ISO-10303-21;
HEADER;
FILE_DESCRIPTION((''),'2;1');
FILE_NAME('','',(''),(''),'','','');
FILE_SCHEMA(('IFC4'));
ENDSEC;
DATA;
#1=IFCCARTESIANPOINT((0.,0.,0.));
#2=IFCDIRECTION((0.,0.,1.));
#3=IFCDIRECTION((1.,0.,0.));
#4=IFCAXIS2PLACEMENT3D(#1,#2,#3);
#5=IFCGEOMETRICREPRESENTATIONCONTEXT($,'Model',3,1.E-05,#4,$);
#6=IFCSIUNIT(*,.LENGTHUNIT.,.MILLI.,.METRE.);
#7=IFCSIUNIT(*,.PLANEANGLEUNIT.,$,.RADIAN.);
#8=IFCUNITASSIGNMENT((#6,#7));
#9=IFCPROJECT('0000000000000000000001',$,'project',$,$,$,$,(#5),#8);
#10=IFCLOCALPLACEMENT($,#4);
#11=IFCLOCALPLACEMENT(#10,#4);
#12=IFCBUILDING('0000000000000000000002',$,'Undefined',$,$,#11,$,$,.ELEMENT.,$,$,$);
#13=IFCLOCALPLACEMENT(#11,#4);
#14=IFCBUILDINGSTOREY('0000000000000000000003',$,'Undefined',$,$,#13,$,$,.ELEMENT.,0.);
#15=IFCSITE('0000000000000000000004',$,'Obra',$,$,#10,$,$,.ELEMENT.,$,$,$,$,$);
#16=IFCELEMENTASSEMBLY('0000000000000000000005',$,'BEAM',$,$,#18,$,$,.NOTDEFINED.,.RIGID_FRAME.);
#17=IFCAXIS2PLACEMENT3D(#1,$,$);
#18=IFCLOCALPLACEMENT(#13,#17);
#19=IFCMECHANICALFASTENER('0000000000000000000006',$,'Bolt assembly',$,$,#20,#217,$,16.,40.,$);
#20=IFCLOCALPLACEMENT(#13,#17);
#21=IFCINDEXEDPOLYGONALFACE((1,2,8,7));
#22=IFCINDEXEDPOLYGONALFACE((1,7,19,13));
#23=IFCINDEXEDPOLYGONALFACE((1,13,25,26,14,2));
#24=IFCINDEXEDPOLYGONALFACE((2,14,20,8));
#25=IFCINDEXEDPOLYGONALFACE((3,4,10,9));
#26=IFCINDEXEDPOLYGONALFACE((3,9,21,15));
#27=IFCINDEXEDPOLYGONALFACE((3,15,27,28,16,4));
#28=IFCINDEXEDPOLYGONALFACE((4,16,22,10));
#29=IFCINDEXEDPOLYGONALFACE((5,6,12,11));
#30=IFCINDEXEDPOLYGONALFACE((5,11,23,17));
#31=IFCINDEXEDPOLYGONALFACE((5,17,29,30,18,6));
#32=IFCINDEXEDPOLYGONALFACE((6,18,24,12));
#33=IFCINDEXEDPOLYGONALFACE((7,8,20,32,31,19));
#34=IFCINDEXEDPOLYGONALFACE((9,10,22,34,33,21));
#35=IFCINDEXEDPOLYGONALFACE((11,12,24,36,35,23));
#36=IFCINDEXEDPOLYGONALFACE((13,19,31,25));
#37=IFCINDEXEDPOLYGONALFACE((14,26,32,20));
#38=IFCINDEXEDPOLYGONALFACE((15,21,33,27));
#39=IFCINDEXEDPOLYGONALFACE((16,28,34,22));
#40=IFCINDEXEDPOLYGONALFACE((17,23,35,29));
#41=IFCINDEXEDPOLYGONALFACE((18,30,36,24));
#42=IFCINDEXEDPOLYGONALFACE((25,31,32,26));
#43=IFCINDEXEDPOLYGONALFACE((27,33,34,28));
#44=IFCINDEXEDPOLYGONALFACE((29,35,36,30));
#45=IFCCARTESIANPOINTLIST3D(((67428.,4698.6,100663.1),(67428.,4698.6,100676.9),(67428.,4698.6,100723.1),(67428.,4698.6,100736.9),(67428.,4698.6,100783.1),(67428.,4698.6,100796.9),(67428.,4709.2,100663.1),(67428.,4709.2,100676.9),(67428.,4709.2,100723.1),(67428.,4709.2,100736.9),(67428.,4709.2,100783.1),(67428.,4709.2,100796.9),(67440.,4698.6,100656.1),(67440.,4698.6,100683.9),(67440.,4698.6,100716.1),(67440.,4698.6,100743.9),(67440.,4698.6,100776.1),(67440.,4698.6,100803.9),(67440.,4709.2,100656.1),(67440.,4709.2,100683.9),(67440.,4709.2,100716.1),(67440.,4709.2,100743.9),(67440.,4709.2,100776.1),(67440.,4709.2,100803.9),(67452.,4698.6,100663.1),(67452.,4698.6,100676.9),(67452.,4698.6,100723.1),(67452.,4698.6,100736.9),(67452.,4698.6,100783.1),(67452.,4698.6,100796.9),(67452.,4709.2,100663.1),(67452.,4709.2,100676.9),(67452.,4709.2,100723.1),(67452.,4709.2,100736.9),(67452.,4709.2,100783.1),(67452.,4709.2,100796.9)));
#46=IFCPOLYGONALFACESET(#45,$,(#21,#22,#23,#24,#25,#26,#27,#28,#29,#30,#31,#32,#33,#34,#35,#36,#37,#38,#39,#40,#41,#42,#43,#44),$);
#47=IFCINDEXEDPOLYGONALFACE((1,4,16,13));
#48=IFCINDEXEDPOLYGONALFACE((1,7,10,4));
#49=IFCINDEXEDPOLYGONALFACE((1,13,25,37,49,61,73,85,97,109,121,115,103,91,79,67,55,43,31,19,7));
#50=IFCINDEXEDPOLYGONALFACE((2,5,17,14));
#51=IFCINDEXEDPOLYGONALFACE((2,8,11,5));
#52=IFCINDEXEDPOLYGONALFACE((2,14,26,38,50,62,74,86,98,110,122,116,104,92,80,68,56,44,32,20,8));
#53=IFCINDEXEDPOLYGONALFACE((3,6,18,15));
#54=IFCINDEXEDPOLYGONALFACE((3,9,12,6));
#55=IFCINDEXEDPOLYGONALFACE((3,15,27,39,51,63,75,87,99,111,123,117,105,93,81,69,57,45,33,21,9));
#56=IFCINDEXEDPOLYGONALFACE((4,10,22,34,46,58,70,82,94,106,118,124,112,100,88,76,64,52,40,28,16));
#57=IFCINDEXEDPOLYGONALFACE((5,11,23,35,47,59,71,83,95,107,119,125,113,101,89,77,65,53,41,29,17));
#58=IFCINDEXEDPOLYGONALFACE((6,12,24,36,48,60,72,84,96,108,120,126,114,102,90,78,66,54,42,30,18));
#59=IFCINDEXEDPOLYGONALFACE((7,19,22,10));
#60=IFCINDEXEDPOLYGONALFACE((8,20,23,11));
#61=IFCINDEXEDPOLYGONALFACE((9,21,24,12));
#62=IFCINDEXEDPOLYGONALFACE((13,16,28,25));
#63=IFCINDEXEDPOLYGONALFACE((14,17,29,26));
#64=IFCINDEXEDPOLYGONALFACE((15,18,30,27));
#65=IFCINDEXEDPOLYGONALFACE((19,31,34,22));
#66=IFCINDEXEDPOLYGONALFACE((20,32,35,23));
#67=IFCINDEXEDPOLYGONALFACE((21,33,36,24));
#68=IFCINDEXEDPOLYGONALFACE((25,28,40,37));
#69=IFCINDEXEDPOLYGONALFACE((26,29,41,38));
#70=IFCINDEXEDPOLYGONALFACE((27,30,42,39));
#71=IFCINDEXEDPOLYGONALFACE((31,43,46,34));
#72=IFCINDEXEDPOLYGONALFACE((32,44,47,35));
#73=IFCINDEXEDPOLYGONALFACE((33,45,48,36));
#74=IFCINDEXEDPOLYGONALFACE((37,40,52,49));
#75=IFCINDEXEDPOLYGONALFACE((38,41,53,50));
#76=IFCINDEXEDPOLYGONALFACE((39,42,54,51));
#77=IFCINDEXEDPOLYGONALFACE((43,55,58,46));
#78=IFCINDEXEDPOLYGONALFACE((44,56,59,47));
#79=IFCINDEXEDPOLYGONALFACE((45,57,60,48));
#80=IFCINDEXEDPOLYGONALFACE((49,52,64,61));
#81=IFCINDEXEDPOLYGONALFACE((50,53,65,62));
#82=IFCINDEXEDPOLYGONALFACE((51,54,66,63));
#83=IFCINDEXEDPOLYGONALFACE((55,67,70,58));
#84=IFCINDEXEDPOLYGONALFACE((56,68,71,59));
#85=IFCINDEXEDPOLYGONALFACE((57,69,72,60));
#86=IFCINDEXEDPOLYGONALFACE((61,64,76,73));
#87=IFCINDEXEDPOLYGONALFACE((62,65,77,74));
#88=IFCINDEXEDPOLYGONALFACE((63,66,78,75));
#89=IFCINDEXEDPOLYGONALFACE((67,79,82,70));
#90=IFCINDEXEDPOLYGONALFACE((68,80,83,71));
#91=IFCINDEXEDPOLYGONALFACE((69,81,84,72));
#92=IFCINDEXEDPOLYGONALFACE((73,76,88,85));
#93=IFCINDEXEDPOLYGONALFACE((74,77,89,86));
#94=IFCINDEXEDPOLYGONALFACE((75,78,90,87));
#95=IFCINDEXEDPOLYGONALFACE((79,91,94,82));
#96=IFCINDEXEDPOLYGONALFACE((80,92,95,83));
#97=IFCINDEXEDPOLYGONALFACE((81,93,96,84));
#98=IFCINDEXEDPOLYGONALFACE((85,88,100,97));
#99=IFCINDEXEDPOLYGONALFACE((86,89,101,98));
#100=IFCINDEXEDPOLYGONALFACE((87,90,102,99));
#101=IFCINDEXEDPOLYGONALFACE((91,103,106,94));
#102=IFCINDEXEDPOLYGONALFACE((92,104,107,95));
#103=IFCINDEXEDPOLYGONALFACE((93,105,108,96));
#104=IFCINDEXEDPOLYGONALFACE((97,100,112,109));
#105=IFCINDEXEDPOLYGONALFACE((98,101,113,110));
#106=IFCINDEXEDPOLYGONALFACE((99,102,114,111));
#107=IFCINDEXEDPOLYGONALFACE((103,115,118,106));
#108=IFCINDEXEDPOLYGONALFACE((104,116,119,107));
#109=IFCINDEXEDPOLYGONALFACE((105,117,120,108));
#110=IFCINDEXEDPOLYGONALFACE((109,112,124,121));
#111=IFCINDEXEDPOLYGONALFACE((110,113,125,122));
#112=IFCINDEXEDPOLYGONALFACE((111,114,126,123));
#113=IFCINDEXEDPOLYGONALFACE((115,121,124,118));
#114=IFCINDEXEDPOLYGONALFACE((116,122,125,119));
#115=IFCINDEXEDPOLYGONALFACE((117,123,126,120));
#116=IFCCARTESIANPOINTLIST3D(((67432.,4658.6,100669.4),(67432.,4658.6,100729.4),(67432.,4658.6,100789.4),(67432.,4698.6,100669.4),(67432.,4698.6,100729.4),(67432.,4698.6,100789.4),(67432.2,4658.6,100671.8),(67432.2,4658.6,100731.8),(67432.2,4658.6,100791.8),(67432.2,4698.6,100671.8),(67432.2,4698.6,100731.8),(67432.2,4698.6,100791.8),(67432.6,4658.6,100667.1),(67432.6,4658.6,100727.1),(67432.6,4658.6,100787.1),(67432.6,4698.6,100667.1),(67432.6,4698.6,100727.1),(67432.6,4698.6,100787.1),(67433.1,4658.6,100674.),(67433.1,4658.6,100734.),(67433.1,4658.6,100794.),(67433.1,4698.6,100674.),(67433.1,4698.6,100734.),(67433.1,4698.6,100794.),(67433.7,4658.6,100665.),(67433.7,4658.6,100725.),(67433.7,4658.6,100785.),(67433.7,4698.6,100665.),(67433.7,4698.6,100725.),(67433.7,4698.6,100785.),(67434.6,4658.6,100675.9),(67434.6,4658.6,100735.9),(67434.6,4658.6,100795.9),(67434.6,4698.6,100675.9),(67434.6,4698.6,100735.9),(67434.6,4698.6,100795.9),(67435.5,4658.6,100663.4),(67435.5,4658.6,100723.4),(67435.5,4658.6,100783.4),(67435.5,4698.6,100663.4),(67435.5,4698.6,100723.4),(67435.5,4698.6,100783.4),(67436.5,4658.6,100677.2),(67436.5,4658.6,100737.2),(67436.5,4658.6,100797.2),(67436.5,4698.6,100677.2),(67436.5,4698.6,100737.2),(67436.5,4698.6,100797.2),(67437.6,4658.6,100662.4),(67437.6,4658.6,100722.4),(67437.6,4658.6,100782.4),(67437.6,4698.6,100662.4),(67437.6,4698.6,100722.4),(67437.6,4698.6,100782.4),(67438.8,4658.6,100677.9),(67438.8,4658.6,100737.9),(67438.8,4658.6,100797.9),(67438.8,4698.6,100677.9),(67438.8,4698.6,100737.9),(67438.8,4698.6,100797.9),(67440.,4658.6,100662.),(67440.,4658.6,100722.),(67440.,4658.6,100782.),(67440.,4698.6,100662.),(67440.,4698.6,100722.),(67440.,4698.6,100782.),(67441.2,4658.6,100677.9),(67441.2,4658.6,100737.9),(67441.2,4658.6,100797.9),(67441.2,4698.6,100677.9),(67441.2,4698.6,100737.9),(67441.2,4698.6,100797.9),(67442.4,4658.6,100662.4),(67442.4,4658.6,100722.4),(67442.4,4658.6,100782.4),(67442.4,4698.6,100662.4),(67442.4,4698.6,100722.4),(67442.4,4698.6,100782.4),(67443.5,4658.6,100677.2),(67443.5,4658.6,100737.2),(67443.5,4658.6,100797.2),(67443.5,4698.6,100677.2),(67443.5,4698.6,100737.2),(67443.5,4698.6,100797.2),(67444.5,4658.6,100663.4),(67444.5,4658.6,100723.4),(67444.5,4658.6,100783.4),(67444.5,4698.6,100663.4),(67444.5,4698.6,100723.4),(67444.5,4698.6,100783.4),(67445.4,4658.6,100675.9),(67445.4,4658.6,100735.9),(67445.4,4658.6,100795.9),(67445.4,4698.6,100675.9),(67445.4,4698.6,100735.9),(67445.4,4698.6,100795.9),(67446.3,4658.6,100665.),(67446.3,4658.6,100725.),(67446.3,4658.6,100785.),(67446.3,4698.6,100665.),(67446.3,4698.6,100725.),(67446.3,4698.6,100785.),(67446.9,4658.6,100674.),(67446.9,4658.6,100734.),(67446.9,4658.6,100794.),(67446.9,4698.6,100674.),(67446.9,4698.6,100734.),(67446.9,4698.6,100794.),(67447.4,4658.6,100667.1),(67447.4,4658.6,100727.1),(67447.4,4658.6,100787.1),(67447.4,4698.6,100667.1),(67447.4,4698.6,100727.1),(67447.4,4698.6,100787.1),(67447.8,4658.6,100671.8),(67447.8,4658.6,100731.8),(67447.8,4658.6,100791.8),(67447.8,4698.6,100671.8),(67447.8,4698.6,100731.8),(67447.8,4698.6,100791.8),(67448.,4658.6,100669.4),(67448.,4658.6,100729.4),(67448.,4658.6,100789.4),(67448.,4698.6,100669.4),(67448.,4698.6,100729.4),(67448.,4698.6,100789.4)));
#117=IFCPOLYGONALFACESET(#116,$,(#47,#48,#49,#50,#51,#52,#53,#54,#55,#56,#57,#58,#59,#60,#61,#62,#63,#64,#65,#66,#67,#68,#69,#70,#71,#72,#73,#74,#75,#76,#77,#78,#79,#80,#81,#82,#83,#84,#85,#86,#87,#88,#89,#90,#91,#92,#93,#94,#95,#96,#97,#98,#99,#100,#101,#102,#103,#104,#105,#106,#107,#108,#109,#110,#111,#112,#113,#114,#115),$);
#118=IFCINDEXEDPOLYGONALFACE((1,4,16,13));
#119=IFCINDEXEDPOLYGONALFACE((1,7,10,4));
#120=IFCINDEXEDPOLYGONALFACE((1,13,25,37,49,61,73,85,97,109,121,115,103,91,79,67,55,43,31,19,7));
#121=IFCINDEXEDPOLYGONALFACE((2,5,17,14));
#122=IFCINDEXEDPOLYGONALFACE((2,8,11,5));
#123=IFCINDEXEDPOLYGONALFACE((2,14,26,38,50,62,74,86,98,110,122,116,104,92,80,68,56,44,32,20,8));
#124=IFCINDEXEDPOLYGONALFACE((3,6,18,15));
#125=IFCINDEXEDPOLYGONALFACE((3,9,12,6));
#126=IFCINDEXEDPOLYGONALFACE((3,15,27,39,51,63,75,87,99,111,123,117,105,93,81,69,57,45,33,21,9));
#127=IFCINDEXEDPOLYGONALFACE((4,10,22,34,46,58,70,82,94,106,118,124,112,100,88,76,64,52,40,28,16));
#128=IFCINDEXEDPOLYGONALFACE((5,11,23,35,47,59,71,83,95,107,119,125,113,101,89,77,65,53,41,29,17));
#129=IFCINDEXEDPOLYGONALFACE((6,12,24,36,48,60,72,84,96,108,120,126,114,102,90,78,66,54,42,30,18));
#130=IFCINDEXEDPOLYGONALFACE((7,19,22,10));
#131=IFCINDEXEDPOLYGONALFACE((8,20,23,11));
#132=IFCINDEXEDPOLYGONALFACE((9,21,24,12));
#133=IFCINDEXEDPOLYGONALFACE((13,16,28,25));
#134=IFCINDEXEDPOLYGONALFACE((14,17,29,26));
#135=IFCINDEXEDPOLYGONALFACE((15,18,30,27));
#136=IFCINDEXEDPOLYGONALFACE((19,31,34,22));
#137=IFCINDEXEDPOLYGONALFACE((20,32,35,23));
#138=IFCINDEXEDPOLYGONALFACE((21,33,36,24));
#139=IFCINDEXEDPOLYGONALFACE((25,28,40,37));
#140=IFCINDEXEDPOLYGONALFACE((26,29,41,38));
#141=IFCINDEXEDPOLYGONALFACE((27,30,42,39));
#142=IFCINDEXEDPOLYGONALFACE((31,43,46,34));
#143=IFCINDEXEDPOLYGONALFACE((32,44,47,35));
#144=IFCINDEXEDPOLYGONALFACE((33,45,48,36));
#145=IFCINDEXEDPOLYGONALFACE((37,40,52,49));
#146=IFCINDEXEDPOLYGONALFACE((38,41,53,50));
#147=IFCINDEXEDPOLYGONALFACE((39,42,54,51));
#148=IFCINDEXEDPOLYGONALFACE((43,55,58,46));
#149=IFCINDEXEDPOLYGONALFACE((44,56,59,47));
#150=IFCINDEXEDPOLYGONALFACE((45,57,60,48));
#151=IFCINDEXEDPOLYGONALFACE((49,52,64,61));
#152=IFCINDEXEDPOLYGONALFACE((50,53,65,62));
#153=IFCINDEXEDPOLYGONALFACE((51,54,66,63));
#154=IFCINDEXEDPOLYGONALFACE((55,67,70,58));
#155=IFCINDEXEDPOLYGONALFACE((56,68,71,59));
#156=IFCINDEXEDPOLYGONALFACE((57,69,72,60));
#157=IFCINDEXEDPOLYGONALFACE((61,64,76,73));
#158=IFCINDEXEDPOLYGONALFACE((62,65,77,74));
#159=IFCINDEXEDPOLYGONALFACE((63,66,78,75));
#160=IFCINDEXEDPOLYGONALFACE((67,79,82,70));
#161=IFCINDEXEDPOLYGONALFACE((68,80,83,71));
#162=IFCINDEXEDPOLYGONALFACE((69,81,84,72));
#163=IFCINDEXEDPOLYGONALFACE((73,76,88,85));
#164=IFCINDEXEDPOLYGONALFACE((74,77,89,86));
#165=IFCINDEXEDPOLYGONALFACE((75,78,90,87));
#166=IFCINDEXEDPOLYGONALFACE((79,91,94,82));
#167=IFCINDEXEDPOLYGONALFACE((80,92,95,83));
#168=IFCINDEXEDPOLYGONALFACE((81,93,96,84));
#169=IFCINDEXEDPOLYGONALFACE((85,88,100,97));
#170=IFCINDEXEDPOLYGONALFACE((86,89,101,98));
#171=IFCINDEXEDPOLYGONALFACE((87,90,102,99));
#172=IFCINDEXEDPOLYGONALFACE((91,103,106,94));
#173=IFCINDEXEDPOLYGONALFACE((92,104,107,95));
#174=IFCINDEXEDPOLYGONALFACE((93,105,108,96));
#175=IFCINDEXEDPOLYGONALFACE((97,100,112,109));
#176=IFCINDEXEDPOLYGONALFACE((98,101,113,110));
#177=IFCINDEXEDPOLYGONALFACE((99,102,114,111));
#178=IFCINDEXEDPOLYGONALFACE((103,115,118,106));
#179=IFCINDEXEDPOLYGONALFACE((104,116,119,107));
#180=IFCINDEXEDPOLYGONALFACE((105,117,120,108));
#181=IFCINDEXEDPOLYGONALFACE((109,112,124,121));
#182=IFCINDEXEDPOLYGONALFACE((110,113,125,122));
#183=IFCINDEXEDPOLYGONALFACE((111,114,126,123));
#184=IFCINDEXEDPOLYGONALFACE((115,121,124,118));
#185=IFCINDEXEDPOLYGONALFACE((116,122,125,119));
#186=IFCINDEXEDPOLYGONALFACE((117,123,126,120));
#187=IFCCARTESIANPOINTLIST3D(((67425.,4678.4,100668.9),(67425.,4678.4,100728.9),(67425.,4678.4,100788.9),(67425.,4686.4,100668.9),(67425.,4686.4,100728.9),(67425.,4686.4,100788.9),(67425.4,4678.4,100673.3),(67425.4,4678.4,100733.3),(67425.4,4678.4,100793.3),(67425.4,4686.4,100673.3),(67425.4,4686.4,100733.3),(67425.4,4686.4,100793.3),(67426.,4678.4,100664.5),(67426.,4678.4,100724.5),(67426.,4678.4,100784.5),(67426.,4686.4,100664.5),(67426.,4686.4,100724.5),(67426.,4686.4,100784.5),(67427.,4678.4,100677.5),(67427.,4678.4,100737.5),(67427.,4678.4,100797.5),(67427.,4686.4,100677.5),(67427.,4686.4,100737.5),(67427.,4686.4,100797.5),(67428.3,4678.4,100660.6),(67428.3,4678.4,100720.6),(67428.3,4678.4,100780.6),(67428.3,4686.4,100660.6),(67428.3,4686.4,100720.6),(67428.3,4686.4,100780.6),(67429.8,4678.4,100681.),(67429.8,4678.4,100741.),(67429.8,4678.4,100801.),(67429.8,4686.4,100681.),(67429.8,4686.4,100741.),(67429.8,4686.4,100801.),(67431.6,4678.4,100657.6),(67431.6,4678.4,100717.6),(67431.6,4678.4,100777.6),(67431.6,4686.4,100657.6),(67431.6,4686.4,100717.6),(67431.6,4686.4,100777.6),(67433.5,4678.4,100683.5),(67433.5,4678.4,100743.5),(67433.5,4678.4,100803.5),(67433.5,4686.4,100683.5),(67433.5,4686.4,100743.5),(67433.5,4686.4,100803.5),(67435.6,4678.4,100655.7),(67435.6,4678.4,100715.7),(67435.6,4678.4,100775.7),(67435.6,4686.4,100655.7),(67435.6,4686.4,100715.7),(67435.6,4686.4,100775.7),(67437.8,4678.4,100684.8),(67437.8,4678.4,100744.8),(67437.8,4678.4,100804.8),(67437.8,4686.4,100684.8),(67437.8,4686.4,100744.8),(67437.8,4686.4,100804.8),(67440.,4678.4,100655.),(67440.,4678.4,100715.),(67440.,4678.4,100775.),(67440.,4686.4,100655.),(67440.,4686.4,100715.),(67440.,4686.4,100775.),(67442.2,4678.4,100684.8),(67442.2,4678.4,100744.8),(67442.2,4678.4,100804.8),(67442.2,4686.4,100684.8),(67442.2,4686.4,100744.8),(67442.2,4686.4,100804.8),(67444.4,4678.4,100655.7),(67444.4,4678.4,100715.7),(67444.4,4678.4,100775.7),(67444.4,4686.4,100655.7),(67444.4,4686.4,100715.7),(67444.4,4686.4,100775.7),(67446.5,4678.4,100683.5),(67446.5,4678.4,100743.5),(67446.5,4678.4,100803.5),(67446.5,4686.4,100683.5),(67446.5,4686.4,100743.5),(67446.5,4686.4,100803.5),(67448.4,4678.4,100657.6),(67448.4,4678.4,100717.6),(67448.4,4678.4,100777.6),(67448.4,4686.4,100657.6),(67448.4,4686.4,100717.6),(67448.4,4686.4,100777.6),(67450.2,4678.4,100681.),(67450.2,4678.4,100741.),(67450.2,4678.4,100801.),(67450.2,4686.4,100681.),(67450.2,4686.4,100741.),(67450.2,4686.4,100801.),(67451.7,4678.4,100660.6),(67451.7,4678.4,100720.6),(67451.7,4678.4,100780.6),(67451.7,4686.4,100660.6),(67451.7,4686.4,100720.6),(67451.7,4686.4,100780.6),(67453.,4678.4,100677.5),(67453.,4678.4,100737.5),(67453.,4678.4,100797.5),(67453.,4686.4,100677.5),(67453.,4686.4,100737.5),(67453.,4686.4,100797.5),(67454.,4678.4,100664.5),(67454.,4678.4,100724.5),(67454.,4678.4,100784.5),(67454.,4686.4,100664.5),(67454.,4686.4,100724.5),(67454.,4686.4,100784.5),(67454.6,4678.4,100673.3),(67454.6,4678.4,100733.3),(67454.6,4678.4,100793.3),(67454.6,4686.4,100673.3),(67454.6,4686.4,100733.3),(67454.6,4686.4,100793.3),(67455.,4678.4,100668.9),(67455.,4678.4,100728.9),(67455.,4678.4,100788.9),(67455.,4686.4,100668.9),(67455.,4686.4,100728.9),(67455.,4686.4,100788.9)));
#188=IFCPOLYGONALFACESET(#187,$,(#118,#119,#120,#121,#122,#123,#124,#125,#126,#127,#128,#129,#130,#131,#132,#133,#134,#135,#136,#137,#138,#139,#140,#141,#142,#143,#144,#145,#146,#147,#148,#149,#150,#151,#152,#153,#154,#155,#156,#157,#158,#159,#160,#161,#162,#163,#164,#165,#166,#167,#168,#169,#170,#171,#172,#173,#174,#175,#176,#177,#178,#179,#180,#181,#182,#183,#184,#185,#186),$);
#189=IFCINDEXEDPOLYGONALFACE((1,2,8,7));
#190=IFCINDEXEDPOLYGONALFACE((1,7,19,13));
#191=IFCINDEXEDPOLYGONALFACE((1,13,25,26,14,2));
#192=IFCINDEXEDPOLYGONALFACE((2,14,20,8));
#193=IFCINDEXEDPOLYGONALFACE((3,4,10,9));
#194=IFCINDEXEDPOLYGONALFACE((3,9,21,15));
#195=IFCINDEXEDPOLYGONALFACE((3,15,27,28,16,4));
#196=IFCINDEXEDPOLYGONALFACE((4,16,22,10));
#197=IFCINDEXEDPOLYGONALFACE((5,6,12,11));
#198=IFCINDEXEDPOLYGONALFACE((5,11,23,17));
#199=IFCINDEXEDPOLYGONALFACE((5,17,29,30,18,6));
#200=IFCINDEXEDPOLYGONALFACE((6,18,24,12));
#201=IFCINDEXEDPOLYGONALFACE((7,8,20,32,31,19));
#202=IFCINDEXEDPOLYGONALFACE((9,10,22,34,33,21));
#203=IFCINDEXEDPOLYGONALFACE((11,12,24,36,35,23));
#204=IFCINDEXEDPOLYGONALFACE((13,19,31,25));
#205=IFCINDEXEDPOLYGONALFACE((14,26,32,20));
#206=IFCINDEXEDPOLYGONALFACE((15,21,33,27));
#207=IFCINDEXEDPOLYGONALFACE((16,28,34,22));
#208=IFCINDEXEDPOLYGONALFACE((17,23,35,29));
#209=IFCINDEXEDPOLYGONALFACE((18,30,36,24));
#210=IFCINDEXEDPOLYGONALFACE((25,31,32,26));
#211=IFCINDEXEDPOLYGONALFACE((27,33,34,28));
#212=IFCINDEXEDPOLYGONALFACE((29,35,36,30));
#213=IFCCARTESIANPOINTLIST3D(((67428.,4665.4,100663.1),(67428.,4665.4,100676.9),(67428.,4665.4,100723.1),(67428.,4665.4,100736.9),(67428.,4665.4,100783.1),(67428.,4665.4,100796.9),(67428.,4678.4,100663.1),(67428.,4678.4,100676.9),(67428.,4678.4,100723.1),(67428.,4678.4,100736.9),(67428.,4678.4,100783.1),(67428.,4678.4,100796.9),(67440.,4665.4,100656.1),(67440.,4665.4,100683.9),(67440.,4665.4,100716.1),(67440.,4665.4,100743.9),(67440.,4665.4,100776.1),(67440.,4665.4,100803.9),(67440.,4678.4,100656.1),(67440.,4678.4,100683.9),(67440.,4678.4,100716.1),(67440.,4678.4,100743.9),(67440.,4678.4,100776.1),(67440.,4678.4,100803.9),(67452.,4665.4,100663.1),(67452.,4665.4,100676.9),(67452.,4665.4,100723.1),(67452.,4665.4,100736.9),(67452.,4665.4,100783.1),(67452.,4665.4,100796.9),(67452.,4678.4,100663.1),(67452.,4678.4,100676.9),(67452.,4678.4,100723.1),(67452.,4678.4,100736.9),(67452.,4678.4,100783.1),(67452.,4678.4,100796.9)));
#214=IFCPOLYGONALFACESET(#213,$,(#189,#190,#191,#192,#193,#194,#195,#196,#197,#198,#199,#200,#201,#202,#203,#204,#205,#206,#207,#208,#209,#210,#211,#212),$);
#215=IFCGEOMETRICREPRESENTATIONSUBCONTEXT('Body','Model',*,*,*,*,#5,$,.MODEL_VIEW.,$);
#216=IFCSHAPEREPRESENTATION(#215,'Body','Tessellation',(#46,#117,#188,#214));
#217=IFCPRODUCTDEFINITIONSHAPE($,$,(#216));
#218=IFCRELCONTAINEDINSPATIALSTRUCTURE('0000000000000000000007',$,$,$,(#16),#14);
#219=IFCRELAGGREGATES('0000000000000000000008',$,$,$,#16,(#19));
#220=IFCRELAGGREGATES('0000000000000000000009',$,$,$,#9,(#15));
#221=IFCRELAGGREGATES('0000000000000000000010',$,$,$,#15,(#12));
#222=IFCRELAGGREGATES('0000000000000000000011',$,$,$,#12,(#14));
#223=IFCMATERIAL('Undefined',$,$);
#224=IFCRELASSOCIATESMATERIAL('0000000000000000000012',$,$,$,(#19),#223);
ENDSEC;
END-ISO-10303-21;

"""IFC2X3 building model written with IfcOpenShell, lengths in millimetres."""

from ifc_helpers import new_model, si_unit, frame, origin_with_axes, origin_2d_with_axis, place, context, subcontext, project, spatial, polyline, circle, outline, extrude, source, transform, mapped, material, element, aggregate, save


model = new_model("IFC2X3")

# Units and contexts
model_context = context("Model", 3, precision=1e-05, world=origin_with_axes())
body_context = subcontext(model_context, "Body", "Model", "MODEL_VIEW")
ifc_project = project(units=[si_unit("LENGTHUNIT", "METRE", prefix="MILLI"), si_unit("PLANEANGLEUNIT", "RADIAN")], contexts=[model_context])

# Site, building, storey
site_placement = place(None, origin_with_axes())
site = spatial("IfcSite", under=ifc_project, at=site_placement, Name="Obra", CompositionType="ELEMENT")
building_placement = place(site_placement, origin_with_axes())
building = spatial("IfcBuilding", under=site, at=building_placement, Name="Undefined", CompositionType="ELEMENT")
storey_placement = place(building_placement, origin_with_axes())
storey = spatial("IfcBuildingStorey", under=building, at=storey_placement, Name="Undefined", CompositionType="ELEMENT", Elevation=0.0)

# Shared definitions
ifc_material_1 = material(Name="Undefined")

# Element assembly, mechanical fastener
assembly_1_placement = place(storey_placement, origin_with_axes())
assembly_1 = element("IfcElementAssembly", 1, at=assembly_1_placement, inside=storey, Name="BEAM", AssemblyPlace="NOTDEFINED", PredefinedType="RIGID_FRAME")
shared_shape_1 = source(origin_with_axes(), body_context, "Body", "SweptSolid", [
    extrude(outline(polyline([(13.9, 0.0), (6.9, 12.0), (-6.9, 12.0), (-13.9, 0.0), (-6.9, -12.0), (6.9, -12.0), (13.9, 0.0)])), frame((0.0, -19.7, 0.0), z_axis=(0.0, 1.0, 0.0), x_axis=(1.0, 0.0, 0.0)), (0.0, 0.0, 1.0), 10.6),
    extrude(circle(Radius=8.0, at=origin_2d_with_axis()), frame((0.0, -9.1, 0.0), z_axis=(0.0, 1.0, 0.0), x_axis=(1.0, 0.0, 0.0)), (0.0, 0.0, 1.0), 40.0),
    extrude(circle(Radius=15.0, at=origin_2d_with_axis()), frame((0.0, 3.1, 0.0), z_axis=(0.0, 1.0, 0.0), x_axis=(1.0, 0.0, 0.0)), (0.0, 0.0, 1.0), 8.0),
    extrude(outline(polyline([(13.9, 0.0), (6.9, 12.0), (-6.9, 12.0), (-13.9, 0.0), (-6.9, -12.0), (6.9, -12.0), (13.9, 0.0)])), frame((0.0, 11.1, 0.0), z_axis=(0.0, 1.0, 0.0), x_axis=(1.0, 0.0, 0.0)), (0.0, 0.0, 1.0), 13.0),
])
mechanical_fastener_1_placement = place(assembly_1_placement, frame((67490.0, 4689.5, 100850.0), z_axis=(-1.0, 0.0, 0.0), x_axis=(0.0, 0.0, -1.0)))
mechanical_fastener_1 = element("IfcMechanicalFastener", 2, at=mechanical_fastener_1_placement, material=ifc_material_1, Name="Bolt assembly", NominalDiameter=16.0, NominalLength=40.0, context=body_context, shape_type="MappedRepresentation", body=[
    mapped(shared_shape_1, transform((60.0, 0.0, 50.0))),
    mapped(shared_shape_1, transform((120.0, 0.0, 50.0))),
    mapped(shared_shape_1, transform((180.0, 0.0, 50.0))),
])

aggregate(assembly_1, [mechanical_fastener_1])

save(model, "model.ifc")
